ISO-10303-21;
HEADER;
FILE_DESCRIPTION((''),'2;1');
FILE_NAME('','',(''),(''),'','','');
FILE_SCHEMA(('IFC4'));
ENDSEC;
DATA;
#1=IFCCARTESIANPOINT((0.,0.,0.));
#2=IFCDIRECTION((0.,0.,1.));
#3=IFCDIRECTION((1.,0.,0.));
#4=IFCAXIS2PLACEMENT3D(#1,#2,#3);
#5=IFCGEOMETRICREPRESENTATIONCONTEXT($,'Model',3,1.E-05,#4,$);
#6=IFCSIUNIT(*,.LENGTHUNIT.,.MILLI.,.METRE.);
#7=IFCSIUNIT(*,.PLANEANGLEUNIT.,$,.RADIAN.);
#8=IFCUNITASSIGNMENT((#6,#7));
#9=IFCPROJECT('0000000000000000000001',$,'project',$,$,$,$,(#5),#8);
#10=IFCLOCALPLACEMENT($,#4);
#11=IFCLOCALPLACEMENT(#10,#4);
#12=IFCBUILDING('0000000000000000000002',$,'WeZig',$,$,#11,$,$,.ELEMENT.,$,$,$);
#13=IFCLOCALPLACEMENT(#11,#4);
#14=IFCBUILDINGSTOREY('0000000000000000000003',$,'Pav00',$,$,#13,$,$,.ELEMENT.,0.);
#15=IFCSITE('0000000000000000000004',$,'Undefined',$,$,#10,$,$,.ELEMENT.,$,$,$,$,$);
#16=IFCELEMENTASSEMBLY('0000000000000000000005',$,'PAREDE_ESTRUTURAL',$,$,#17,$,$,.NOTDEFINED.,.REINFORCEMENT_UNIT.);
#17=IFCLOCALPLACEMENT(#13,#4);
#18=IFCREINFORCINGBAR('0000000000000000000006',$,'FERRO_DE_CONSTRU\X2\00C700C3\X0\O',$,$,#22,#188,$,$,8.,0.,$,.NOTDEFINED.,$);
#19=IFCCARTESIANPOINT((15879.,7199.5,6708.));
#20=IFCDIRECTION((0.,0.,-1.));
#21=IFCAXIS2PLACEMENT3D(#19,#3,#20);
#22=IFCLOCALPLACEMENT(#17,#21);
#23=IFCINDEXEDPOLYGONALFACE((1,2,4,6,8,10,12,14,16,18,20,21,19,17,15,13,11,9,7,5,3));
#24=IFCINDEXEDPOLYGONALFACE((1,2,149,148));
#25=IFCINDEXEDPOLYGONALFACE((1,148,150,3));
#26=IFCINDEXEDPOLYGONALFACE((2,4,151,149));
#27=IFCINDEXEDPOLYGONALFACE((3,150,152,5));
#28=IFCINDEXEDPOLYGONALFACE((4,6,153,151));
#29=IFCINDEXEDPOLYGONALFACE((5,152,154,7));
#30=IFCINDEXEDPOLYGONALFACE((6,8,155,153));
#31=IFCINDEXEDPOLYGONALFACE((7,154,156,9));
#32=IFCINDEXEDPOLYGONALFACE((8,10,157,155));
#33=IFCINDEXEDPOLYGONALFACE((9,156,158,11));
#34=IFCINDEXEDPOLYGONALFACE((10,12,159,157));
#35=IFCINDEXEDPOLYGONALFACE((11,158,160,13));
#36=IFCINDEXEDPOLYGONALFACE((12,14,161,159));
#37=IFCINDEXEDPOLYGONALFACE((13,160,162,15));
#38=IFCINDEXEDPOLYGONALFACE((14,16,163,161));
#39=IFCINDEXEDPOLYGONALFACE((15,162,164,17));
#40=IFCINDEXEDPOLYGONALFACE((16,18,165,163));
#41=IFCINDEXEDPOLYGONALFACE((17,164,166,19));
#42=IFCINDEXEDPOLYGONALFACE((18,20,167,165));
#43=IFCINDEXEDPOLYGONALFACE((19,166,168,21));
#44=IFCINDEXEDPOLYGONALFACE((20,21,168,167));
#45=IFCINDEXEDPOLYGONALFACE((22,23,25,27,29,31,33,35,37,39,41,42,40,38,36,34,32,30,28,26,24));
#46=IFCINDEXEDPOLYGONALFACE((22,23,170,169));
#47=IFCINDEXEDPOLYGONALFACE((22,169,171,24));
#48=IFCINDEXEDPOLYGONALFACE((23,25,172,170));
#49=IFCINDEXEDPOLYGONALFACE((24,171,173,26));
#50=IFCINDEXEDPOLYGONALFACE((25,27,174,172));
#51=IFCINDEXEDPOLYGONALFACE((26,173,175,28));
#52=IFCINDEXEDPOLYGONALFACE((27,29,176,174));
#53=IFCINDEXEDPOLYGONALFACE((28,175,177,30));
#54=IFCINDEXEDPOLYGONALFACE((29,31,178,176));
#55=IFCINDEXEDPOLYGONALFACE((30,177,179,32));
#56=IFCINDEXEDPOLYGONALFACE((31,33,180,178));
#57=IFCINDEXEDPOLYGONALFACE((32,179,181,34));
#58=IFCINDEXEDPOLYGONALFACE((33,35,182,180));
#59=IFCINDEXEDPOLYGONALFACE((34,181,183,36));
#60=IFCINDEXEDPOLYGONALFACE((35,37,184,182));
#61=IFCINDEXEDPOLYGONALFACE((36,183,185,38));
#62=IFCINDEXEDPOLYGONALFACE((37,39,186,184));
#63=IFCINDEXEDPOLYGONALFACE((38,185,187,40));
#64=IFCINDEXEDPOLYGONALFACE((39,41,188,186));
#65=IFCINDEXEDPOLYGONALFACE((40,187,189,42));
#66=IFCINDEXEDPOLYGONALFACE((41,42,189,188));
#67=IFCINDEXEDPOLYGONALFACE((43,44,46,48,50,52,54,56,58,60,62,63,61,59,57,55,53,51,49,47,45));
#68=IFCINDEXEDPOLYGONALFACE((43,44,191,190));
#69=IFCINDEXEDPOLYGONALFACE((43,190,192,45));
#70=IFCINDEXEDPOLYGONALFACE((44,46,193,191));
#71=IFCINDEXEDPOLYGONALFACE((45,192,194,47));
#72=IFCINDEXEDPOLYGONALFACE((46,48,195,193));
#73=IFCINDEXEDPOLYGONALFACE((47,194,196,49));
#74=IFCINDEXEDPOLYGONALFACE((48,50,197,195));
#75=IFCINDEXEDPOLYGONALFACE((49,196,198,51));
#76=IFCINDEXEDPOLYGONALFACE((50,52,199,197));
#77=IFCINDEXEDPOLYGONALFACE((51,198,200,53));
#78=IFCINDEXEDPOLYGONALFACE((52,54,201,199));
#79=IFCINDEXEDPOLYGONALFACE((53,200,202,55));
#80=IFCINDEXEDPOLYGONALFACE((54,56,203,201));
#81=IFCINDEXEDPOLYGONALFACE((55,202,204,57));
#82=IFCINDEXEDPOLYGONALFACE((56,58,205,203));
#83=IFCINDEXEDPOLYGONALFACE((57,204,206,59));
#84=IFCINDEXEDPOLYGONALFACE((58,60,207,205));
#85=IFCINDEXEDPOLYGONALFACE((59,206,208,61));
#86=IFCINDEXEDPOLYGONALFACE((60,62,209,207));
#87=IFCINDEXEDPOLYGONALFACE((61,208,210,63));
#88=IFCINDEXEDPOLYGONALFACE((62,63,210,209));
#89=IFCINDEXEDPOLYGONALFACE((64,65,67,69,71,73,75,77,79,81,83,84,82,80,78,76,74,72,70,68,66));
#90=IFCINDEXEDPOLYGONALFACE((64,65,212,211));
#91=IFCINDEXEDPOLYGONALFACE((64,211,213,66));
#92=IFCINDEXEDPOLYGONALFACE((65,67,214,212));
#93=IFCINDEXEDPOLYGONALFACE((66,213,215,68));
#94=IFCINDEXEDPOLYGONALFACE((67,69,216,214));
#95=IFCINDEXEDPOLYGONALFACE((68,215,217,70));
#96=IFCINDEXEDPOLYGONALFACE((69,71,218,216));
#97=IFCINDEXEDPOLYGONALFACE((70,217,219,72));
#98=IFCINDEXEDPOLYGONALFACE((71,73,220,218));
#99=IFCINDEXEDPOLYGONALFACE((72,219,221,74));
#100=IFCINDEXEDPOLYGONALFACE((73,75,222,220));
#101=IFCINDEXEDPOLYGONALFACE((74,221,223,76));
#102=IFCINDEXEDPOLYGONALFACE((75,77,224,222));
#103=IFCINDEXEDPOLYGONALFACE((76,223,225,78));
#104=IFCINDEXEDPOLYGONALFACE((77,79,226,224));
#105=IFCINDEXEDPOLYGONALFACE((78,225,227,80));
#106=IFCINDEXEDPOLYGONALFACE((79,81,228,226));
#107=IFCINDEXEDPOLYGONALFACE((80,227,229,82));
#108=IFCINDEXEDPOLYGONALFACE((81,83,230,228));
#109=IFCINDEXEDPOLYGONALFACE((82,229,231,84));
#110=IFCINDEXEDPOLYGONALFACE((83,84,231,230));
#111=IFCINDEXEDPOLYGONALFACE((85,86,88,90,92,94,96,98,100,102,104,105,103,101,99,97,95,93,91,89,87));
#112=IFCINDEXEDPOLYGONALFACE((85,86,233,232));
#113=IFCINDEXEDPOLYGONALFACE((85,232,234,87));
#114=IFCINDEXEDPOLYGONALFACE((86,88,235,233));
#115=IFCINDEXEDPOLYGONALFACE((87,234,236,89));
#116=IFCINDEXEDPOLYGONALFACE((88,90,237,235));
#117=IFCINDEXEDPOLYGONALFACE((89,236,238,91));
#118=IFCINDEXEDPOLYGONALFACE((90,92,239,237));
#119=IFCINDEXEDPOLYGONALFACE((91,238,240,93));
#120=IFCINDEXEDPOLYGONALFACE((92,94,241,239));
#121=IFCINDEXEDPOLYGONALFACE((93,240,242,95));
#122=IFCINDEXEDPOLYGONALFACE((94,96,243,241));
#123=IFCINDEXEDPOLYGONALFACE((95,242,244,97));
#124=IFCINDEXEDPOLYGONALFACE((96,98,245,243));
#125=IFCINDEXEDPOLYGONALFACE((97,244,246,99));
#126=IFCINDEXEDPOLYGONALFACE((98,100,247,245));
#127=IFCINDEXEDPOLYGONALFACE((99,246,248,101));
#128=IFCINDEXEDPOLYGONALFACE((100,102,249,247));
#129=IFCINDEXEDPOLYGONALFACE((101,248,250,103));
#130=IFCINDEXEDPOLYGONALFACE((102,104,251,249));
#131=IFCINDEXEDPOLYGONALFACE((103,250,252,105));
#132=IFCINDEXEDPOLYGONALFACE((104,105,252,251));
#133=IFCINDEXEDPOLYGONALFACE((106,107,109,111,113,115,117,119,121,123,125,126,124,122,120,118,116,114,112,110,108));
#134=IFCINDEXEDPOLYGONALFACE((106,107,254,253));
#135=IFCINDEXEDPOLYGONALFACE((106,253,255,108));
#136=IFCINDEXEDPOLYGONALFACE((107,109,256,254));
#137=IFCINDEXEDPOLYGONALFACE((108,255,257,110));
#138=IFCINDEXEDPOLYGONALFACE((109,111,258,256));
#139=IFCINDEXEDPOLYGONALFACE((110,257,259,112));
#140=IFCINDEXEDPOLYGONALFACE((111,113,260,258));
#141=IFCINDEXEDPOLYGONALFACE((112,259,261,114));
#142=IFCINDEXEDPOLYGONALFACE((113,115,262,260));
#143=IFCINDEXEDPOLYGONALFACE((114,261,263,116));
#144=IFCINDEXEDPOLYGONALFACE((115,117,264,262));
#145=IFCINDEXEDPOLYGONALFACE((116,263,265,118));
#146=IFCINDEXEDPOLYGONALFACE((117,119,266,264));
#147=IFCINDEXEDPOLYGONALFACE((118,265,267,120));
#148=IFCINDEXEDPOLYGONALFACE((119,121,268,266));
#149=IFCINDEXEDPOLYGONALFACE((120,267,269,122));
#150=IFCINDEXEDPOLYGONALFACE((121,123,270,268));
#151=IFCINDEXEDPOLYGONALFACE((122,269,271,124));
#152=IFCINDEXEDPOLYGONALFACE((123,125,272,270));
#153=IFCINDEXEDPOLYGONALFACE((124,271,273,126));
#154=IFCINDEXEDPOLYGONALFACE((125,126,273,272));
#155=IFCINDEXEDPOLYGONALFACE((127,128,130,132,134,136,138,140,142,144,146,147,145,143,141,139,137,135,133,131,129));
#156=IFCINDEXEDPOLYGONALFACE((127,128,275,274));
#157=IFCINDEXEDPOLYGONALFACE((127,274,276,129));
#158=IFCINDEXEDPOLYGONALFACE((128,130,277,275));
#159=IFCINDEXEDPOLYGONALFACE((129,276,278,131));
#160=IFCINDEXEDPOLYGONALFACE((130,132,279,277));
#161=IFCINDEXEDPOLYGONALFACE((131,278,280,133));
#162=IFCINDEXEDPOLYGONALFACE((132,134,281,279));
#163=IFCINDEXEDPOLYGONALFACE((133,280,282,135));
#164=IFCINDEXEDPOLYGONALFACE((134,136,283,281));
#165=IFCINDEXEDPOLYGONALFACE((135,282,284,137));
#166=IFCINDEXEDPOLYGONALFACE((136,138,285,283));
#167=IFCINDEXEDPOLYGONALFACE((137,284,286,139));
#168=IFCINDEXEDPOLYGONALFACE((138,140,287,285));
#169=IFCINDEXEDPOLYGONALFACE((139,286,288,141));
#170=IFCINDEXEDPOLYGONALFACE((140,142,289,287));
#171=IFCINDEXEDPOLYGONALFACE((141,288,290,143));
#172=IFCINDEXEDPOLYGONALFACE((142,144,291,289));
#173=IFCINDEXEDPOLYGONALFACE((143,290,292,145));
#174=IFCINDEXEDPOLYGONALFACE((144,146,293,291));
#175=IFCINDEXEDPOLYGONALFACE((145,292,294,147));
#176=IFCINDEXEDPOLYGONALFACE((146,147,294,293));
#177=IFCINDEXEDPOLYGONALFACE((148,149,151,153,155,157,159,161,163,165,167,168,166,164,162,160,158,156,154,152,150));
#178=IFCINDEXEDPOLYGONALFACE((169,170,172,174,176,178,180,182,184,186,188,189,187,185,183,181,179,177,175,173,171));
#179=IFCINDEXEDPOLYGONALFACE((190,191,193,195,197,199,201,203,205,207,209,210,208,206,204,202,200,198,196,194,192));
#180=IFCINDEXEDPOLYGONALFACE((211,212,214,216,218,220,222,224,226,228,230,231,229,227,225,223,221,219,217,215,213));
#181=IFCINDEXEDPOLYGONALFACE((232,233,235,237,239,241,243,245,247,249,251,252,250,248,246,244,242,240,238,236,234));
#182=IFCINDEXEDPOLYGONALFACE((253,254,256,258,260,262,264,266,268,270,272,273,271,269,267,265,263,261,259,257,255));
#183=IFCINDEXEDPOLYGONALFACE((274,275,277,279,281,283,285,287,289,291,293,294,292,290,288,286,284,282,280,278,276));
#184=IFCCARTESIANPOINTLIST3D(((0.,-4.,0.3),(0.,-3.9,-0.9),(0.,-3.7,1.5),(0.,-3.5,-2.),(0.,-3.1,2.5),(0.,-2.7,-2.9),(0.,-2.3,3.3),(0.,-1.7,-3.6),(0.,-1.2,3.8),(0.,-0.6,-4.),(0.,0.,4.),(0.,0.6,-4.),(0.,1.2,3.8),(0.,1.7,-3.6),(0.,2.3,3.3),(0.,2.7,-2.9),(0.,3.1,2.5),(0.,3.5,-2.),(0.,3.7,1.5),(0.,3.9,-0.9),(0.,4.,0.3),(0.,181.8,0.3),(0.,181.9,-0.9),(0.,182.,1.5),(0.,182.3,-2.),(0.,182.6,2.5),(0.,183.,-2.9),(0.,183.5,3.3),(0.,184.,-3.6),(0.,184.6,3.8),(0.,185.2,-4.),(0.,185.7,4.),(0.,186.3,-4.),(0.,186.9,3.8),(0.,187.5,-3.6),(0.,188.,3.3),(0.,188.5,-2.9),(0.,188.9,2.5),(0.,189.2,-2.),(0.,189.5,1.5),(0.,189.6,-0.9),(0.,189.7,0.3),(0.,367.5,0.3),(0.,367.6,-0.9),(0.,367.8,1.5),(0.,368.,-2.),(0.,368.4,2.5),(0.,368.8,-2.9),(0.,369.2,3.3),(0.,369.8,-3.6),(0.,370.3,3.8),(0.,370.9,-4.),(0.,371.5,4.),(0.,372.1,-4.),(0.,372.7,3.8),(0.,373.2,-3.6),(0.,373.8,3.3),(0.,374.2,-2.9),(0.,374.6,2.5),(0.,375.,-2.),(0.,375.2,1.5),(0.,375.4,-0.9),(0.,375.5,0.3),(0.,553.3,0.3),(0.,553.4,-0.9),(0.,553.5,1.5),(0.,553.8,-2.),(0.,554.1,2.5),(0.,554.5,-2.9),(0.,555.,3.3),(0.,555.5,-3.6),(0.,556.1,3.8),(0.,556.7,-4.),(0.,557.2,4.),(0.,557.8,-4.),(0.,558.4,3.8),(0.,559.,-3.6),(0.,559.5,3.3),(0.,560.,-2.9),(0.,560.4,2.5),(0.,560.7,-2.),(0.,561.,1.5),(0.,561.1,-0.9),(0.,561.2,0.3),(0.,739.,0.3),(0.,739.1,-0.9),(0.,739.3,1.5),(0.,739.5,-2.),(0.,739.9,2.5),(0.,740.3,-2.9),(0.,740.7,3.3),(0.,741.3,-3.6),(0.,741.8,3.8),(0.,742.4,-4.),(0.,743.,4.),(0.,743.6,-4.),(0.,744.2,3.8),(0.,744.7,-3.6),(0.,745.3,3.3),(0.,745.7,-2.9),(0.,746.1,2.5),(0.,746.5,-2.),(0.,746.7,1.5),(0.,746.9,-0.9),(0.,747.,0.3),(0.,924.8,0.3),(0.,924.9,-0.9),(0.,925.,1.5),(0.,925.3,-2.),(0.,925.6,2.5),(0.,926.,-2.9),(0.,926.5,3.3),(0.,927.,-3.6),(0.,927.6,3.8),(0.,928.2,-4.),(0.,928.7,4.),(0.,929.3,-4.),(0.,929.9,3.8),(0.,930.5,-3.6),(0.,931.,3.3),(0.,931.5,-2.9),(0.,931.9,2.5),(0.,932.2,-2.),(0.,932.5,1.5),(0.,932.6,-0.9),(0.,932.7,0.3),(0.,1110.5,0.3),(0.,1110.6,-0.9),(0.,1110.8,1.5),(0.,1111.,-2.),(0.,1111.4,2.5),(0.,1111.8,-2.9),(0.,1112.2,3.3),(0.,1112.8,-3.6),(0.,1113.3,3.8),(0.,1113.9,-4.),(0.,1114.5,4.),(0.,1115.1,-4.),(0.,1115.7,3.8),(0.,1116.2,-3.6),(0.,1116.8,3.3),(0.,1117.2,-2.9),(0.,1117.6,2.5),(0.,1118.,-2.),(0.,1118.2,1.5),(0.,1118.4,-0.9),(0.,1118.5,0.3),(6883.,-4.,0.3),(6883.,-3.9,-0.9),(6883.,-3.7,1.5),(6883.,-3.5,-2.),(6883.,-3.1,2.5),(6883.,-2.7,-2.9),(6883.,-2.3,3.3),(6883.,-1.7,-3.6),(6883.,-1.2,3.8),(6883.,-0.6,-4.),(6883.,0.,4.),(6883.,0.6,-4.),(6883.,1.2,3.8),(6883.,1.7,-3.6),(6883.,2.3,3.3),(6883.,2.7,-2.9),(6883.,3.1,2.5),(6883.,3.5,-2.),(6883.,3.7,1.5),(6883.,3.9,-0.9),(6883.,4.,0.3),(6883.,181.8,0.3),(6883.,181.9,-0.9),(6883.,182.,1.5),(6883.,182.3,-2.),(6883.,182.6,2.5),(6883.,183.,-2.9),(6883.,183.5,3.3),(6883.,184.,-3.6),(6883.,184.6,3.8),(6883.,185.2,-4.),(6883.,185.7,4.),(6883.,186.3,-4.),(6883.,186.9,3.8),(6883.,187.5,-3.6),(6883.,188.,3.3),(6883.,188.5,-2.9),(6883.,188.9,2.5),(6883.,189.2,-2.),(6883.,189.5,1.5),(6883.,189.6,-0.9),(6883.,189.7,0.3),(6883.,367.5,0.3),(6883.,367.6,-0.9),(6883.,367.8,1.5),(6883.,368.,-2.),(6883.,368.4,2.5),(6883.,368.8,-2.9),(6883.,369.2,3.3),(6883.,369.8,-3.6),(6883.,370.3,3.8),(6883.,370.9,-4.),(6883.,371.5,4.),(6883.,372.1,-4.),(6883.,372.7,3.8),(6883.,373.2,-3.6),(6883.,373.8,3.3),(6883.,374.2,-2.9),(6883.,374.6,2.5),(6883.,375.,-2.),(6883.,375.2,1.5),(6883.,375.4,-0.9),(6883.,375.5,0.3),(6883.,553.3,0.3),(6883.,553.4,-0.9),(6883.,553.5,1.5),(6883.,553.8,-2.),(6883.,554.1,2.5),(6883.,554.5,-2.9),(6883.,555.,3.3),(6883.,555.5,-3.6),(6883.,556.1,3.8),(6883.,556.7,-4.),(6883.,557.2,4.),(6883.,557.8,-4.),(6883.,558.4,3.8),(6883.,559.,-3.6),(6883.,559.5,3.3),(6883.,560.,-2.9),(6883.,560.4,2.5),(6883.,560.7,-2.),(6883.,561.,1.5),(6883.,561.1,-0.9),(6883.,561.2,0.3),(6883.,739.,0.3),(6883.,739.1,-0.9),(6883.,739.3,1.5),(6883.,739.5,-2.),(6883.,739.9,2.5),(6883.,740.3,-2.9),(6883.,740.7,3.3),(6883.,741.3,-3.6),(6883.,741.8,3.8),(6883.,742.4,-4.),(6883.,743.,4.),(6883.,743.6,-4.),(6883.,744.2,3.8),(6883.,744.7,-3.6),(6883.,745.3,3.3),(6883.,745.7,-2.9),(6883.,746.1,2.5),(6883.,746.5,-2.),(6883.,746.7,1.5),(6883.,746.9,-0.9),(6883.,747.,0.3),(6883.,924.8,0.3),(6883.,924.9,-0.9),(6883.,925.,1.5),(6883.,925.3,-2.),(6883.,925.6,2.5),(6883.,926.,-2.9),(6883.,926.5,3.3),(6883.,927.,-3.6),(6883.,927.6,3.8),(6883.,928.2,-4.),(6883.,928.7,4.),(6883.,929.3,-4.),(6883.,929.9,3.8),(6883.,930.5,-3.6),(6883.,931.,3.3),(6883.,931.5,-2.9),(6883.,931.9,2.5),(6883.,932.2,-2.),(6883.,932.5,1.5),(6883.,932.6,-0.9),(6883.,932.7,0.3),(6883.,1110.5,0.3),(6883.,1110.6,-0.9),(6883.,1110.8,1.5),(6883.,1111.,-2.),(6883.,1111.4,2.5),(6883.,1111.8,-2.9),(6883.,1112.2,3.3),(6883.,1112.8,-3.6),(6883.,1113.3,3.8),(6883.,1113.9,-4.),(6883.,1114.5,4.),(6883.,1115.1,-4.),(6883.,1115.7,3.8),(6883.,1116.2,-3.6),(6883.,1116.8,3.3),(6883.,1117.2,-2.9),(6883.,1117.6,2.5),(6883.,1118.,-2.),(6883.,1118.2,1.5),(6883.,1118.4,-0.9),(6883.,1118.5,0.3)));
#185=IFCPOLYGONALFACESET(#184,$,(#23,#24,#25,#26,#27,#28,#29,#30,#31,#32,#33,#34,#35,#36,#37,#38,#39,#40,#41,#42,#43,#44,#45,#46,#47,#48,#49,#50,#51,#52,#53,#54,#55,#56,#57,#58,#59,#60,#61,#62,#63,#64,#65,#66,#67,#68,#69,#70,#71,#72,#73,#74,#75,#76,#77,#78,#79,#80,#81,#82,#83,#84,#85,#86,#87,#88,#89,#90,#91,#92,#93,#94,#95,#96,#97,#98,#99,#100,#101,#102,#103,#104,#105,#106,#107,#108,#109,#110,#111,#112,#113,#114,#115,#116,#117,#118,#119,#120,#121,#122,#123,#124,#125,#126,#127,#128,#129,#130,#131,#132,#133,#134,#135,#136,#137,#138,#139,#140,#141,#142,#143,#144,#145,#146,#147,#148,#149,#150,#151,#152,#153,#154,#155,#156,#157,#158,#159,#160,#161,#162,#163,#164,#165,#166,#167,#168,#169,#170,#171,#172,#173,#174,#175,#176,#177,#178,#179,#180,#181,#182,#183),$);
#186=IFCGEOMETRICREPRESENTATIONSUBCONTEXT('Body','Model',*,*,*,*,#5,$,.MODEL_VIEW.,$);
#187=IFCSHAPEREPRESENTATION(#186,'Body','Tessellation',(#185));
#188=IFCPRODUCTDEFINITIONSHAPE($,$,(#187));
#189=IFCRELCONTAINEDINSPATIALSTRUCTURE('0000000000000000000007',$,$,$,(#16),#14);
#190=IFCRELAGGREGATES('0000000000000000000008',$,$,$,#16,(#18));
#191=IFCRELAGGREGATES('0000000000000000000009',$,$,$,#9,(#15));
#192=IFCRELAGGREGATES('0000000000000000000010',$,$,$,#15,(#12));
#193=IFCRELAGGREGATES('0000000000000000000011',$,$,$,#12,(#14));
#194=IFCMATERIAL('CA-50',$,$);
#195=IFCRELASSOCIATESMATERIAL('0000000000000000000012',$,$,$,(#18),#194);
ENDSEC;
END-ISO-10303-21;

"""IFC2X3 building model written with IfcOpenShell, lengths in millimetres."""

from ifc_helpers import new_model, entity, si_unit, frame, origin_with_axes, place, context, subcontext, project, spatial, source, transform, mapped, material, element, aggregate, save


model = new_model("IFC2X3")

# Units and contexts
model_context = context("Model", 3, precision=1e-05, world=origin_with_axes())
body_context = subcontext(model_context, "Body", "Model", "MODEL_VIEW")
ifc_project = project(units=[si_unit("LENGTHUNIT", "METRE", prefix="MILLI"), si_unit("PLANEANGLEUNIT", "RADIAN")], contexts=[model_context])

# Site, building, storey
site_placement = place(None, origin_with_axes())
site = spatial("IfcSite", under=ifc_project, at=site_placement, Name="Undefined", CompositionType="ELEMENT")
building_placement = place(site_placement, origin_with_axes())
building = spatial("IfcBuilding", under=site, at=building_placement, Name="WeZig", CompositionType="ELEMENT")
storey_placement = place(building_placement, origin_with_axes())
storey = spatial("IfcBuildingStorey", under=building, at=storey_placement, Name="Pav00", CompositionType="ELEMENT", Elevation=0.0)

# Shared definitions
ifc_material_1 = material(Name="CA-50")

# Element assembly, reinforcing bar
assembly_1_placement = place(storey_placement, origin_with_axes())
assembly_1 = element("IfcElementAssembly", 1, at=assembly_1_placement, inside=storey, Name="PAREDE_ESTRUTURAL", AssemblyPlace="NOTDEFINED", PredefinedType="REINFORCEMENT_UNIT")
shared_shape_1 = source(origin_with_axes(), body_context, "Body", "AdvancedSweptSolid", [
    entity("IfcSweptDiskSolid", entity("IfcTrimmedCurve", entity("IfcLine", entity("IfcCartesianPoint", [0.0, 0.0, 0.0]), entity("IfcVector", entity("IfcDirection", [1.0, 0.0, 0.0]), 1.0)), [entity("IfcParameterValue", 0.0)], [entity("IfcParameterValue", 6883.0)], True, "PARAMETER"), 4.0, None, 0.0, 6883.0),
])
shared_shape_2 = source(origin_with_axes(), body_context, "Body", "AdvancedSweptSolid", [
    entity("IfcSweptDiskSolid", entity("IfcTrimmedCurve", entity("IfcLine", entity("IfcCartesianPoint", [0.0, 0.0, 0.0]), entity("IfcVector", entity("IfcDirection", [1.0, 0.0, 0.0]), 1.0)), [entity("IfcParameterValue", 0.0)], [entity("IfcParameterValue", 6883.0)], True, "PARAMETER"), 4.0, None, 0.0, 6883.0),
])
shared_shape_3 = source(origin_with_axes(), body_context, "Body", "AdvancedSweptSolid", [
    entity("IfcSweptDiskSolid", entity("IfcTrimmedCurve", entity("IfcLine", entity("IfcCartesianPoint", [0.0, 0.0, 0.0]), entity("IfcVector", entity("IfcDirection", [1.0, 0.0, 0.0]), 1.0)), [entity("IfcParameterValue", 0.0)], [entity("IfcParameterValue", 6883.0)], True, "PARAMETER"), 4.0, None, 0.0, 6883.0),
])
shared_shape_4 = source(origin_with_axes(), body_context, "Body", "AdvancedSweptSolid", [
    entity("IfcSweptDiskSolid", entity("IfcTrimmedCurve", entity("IfcLine", entity("IfcCartesianPoint", [0.0, 0.0, 0.0]), entity("IfcVector", entity("IfcDirection", [1.0, 0.0, 0.0]), 1.0)), [entity("IfcParameterValue", 0.0)], [entity("IfcParameterValue", 6883.0)], True, "PARAMETER"), 4.0, None, 0.0, 6883.0),
])
shared_shape_5 = source(origin_with_axes(), body_context, "Body", "AdvancedSweptSolid", [
    entity("IfcSweptDiskSolid", entity("IfcTrimmedCurve", entity("IfcLine", entity("IfcCartesianPoint", [0.0, 0.0, 0.0]), entity("IfcVector", entity("IfcDirection", [1.0, 0.0, 0.0]), 1.0)), [entity("IfcParameterValue", 0.0)], [entity("IfcParameterValue", 6883.0)], True, "PARAMETER"), 4.0, None, 0.0, 6883.0),
])
shared_shape_6 = source(origin_with_axes(), body_context, "Body", "AdvancedSweptSolid", [
    entity("IfcSweptDiskSolid", entity("IfcTrimmedCurve", entity("IfcLine", entity("IfcCartesianPoint", [0.0, 0.0, 0.0]), entity("IfcVector", entity("IfcDirection", [1.0, 0.0, 0.0]), 1.0)), [entity("IfcParameterValue", 0.0)], [entity("IfcParameterValue", 6883.0)], True, "PARAMETER"), 4.0, None, 0.0, 6883.0),
])
shared_shape_7 = source(origin_with_axes(), body_context, "Body", "AdvancedSweptSolid", [
    entity("IfcSweptDiskSolid", entity("IfcTrimmedCurve", entity("IfcLine", entity("IfcCartesianPoint", [0.0, 0.0, 0.0]), entity("IfcVector", entity("IfcDirection", [1.0, 0.0, 0.0]), 1.0)), [entity("IfcParameterValue", 0.0)], [entity("IfcParameterValue", 6883.0)], True, "PARAMETER"), 4.0, None, 0.0, 6883.0),
])
reinforcing_bar_1_placement = place(assembly_1_placement, frame((15879.0, 7199.5, 6708.0), z_axis=(1.0, 0.0, 0.0), x_axis=(0.0, 0.0, -1.0)))
reinforcing_bar_1 = element("IfcReinforcingBar", 2, at=reinforcing_bar_1_placement, material=ifc_material_1, Name="FERRO_DE_CONSTRUÇÃO", BarRole="NOTDEFINED", CrossSectionArea=0.0, NominalDiameter=8.0, context=body_context, shape_type="MappedRepresentation", body=[
    mapped(shared_shape_1, transform((0.0, 0.0, 0.0))),
    mapped(shared_shape_2, transform((0.0, 185.7, 0.0))),
    mapped(shared_shape_3, transform((0.0, 371.5, 0.0))),
    mapped(shared_shape_4, transform((0.0, 557.2, 0.0))),
    mapped(shared_shape_5, transform((0.0, 743.0, 0.0))),
    mapped(shared_shape_6, transform((0.0, 928.7, 0.0))),
    mapped(shared_shape_7, transform((0.0, 1114.5, 0.0))),
])
aggregate(assembly_1, [reinforcing_bar_1])

save(model, "model.ifc")
